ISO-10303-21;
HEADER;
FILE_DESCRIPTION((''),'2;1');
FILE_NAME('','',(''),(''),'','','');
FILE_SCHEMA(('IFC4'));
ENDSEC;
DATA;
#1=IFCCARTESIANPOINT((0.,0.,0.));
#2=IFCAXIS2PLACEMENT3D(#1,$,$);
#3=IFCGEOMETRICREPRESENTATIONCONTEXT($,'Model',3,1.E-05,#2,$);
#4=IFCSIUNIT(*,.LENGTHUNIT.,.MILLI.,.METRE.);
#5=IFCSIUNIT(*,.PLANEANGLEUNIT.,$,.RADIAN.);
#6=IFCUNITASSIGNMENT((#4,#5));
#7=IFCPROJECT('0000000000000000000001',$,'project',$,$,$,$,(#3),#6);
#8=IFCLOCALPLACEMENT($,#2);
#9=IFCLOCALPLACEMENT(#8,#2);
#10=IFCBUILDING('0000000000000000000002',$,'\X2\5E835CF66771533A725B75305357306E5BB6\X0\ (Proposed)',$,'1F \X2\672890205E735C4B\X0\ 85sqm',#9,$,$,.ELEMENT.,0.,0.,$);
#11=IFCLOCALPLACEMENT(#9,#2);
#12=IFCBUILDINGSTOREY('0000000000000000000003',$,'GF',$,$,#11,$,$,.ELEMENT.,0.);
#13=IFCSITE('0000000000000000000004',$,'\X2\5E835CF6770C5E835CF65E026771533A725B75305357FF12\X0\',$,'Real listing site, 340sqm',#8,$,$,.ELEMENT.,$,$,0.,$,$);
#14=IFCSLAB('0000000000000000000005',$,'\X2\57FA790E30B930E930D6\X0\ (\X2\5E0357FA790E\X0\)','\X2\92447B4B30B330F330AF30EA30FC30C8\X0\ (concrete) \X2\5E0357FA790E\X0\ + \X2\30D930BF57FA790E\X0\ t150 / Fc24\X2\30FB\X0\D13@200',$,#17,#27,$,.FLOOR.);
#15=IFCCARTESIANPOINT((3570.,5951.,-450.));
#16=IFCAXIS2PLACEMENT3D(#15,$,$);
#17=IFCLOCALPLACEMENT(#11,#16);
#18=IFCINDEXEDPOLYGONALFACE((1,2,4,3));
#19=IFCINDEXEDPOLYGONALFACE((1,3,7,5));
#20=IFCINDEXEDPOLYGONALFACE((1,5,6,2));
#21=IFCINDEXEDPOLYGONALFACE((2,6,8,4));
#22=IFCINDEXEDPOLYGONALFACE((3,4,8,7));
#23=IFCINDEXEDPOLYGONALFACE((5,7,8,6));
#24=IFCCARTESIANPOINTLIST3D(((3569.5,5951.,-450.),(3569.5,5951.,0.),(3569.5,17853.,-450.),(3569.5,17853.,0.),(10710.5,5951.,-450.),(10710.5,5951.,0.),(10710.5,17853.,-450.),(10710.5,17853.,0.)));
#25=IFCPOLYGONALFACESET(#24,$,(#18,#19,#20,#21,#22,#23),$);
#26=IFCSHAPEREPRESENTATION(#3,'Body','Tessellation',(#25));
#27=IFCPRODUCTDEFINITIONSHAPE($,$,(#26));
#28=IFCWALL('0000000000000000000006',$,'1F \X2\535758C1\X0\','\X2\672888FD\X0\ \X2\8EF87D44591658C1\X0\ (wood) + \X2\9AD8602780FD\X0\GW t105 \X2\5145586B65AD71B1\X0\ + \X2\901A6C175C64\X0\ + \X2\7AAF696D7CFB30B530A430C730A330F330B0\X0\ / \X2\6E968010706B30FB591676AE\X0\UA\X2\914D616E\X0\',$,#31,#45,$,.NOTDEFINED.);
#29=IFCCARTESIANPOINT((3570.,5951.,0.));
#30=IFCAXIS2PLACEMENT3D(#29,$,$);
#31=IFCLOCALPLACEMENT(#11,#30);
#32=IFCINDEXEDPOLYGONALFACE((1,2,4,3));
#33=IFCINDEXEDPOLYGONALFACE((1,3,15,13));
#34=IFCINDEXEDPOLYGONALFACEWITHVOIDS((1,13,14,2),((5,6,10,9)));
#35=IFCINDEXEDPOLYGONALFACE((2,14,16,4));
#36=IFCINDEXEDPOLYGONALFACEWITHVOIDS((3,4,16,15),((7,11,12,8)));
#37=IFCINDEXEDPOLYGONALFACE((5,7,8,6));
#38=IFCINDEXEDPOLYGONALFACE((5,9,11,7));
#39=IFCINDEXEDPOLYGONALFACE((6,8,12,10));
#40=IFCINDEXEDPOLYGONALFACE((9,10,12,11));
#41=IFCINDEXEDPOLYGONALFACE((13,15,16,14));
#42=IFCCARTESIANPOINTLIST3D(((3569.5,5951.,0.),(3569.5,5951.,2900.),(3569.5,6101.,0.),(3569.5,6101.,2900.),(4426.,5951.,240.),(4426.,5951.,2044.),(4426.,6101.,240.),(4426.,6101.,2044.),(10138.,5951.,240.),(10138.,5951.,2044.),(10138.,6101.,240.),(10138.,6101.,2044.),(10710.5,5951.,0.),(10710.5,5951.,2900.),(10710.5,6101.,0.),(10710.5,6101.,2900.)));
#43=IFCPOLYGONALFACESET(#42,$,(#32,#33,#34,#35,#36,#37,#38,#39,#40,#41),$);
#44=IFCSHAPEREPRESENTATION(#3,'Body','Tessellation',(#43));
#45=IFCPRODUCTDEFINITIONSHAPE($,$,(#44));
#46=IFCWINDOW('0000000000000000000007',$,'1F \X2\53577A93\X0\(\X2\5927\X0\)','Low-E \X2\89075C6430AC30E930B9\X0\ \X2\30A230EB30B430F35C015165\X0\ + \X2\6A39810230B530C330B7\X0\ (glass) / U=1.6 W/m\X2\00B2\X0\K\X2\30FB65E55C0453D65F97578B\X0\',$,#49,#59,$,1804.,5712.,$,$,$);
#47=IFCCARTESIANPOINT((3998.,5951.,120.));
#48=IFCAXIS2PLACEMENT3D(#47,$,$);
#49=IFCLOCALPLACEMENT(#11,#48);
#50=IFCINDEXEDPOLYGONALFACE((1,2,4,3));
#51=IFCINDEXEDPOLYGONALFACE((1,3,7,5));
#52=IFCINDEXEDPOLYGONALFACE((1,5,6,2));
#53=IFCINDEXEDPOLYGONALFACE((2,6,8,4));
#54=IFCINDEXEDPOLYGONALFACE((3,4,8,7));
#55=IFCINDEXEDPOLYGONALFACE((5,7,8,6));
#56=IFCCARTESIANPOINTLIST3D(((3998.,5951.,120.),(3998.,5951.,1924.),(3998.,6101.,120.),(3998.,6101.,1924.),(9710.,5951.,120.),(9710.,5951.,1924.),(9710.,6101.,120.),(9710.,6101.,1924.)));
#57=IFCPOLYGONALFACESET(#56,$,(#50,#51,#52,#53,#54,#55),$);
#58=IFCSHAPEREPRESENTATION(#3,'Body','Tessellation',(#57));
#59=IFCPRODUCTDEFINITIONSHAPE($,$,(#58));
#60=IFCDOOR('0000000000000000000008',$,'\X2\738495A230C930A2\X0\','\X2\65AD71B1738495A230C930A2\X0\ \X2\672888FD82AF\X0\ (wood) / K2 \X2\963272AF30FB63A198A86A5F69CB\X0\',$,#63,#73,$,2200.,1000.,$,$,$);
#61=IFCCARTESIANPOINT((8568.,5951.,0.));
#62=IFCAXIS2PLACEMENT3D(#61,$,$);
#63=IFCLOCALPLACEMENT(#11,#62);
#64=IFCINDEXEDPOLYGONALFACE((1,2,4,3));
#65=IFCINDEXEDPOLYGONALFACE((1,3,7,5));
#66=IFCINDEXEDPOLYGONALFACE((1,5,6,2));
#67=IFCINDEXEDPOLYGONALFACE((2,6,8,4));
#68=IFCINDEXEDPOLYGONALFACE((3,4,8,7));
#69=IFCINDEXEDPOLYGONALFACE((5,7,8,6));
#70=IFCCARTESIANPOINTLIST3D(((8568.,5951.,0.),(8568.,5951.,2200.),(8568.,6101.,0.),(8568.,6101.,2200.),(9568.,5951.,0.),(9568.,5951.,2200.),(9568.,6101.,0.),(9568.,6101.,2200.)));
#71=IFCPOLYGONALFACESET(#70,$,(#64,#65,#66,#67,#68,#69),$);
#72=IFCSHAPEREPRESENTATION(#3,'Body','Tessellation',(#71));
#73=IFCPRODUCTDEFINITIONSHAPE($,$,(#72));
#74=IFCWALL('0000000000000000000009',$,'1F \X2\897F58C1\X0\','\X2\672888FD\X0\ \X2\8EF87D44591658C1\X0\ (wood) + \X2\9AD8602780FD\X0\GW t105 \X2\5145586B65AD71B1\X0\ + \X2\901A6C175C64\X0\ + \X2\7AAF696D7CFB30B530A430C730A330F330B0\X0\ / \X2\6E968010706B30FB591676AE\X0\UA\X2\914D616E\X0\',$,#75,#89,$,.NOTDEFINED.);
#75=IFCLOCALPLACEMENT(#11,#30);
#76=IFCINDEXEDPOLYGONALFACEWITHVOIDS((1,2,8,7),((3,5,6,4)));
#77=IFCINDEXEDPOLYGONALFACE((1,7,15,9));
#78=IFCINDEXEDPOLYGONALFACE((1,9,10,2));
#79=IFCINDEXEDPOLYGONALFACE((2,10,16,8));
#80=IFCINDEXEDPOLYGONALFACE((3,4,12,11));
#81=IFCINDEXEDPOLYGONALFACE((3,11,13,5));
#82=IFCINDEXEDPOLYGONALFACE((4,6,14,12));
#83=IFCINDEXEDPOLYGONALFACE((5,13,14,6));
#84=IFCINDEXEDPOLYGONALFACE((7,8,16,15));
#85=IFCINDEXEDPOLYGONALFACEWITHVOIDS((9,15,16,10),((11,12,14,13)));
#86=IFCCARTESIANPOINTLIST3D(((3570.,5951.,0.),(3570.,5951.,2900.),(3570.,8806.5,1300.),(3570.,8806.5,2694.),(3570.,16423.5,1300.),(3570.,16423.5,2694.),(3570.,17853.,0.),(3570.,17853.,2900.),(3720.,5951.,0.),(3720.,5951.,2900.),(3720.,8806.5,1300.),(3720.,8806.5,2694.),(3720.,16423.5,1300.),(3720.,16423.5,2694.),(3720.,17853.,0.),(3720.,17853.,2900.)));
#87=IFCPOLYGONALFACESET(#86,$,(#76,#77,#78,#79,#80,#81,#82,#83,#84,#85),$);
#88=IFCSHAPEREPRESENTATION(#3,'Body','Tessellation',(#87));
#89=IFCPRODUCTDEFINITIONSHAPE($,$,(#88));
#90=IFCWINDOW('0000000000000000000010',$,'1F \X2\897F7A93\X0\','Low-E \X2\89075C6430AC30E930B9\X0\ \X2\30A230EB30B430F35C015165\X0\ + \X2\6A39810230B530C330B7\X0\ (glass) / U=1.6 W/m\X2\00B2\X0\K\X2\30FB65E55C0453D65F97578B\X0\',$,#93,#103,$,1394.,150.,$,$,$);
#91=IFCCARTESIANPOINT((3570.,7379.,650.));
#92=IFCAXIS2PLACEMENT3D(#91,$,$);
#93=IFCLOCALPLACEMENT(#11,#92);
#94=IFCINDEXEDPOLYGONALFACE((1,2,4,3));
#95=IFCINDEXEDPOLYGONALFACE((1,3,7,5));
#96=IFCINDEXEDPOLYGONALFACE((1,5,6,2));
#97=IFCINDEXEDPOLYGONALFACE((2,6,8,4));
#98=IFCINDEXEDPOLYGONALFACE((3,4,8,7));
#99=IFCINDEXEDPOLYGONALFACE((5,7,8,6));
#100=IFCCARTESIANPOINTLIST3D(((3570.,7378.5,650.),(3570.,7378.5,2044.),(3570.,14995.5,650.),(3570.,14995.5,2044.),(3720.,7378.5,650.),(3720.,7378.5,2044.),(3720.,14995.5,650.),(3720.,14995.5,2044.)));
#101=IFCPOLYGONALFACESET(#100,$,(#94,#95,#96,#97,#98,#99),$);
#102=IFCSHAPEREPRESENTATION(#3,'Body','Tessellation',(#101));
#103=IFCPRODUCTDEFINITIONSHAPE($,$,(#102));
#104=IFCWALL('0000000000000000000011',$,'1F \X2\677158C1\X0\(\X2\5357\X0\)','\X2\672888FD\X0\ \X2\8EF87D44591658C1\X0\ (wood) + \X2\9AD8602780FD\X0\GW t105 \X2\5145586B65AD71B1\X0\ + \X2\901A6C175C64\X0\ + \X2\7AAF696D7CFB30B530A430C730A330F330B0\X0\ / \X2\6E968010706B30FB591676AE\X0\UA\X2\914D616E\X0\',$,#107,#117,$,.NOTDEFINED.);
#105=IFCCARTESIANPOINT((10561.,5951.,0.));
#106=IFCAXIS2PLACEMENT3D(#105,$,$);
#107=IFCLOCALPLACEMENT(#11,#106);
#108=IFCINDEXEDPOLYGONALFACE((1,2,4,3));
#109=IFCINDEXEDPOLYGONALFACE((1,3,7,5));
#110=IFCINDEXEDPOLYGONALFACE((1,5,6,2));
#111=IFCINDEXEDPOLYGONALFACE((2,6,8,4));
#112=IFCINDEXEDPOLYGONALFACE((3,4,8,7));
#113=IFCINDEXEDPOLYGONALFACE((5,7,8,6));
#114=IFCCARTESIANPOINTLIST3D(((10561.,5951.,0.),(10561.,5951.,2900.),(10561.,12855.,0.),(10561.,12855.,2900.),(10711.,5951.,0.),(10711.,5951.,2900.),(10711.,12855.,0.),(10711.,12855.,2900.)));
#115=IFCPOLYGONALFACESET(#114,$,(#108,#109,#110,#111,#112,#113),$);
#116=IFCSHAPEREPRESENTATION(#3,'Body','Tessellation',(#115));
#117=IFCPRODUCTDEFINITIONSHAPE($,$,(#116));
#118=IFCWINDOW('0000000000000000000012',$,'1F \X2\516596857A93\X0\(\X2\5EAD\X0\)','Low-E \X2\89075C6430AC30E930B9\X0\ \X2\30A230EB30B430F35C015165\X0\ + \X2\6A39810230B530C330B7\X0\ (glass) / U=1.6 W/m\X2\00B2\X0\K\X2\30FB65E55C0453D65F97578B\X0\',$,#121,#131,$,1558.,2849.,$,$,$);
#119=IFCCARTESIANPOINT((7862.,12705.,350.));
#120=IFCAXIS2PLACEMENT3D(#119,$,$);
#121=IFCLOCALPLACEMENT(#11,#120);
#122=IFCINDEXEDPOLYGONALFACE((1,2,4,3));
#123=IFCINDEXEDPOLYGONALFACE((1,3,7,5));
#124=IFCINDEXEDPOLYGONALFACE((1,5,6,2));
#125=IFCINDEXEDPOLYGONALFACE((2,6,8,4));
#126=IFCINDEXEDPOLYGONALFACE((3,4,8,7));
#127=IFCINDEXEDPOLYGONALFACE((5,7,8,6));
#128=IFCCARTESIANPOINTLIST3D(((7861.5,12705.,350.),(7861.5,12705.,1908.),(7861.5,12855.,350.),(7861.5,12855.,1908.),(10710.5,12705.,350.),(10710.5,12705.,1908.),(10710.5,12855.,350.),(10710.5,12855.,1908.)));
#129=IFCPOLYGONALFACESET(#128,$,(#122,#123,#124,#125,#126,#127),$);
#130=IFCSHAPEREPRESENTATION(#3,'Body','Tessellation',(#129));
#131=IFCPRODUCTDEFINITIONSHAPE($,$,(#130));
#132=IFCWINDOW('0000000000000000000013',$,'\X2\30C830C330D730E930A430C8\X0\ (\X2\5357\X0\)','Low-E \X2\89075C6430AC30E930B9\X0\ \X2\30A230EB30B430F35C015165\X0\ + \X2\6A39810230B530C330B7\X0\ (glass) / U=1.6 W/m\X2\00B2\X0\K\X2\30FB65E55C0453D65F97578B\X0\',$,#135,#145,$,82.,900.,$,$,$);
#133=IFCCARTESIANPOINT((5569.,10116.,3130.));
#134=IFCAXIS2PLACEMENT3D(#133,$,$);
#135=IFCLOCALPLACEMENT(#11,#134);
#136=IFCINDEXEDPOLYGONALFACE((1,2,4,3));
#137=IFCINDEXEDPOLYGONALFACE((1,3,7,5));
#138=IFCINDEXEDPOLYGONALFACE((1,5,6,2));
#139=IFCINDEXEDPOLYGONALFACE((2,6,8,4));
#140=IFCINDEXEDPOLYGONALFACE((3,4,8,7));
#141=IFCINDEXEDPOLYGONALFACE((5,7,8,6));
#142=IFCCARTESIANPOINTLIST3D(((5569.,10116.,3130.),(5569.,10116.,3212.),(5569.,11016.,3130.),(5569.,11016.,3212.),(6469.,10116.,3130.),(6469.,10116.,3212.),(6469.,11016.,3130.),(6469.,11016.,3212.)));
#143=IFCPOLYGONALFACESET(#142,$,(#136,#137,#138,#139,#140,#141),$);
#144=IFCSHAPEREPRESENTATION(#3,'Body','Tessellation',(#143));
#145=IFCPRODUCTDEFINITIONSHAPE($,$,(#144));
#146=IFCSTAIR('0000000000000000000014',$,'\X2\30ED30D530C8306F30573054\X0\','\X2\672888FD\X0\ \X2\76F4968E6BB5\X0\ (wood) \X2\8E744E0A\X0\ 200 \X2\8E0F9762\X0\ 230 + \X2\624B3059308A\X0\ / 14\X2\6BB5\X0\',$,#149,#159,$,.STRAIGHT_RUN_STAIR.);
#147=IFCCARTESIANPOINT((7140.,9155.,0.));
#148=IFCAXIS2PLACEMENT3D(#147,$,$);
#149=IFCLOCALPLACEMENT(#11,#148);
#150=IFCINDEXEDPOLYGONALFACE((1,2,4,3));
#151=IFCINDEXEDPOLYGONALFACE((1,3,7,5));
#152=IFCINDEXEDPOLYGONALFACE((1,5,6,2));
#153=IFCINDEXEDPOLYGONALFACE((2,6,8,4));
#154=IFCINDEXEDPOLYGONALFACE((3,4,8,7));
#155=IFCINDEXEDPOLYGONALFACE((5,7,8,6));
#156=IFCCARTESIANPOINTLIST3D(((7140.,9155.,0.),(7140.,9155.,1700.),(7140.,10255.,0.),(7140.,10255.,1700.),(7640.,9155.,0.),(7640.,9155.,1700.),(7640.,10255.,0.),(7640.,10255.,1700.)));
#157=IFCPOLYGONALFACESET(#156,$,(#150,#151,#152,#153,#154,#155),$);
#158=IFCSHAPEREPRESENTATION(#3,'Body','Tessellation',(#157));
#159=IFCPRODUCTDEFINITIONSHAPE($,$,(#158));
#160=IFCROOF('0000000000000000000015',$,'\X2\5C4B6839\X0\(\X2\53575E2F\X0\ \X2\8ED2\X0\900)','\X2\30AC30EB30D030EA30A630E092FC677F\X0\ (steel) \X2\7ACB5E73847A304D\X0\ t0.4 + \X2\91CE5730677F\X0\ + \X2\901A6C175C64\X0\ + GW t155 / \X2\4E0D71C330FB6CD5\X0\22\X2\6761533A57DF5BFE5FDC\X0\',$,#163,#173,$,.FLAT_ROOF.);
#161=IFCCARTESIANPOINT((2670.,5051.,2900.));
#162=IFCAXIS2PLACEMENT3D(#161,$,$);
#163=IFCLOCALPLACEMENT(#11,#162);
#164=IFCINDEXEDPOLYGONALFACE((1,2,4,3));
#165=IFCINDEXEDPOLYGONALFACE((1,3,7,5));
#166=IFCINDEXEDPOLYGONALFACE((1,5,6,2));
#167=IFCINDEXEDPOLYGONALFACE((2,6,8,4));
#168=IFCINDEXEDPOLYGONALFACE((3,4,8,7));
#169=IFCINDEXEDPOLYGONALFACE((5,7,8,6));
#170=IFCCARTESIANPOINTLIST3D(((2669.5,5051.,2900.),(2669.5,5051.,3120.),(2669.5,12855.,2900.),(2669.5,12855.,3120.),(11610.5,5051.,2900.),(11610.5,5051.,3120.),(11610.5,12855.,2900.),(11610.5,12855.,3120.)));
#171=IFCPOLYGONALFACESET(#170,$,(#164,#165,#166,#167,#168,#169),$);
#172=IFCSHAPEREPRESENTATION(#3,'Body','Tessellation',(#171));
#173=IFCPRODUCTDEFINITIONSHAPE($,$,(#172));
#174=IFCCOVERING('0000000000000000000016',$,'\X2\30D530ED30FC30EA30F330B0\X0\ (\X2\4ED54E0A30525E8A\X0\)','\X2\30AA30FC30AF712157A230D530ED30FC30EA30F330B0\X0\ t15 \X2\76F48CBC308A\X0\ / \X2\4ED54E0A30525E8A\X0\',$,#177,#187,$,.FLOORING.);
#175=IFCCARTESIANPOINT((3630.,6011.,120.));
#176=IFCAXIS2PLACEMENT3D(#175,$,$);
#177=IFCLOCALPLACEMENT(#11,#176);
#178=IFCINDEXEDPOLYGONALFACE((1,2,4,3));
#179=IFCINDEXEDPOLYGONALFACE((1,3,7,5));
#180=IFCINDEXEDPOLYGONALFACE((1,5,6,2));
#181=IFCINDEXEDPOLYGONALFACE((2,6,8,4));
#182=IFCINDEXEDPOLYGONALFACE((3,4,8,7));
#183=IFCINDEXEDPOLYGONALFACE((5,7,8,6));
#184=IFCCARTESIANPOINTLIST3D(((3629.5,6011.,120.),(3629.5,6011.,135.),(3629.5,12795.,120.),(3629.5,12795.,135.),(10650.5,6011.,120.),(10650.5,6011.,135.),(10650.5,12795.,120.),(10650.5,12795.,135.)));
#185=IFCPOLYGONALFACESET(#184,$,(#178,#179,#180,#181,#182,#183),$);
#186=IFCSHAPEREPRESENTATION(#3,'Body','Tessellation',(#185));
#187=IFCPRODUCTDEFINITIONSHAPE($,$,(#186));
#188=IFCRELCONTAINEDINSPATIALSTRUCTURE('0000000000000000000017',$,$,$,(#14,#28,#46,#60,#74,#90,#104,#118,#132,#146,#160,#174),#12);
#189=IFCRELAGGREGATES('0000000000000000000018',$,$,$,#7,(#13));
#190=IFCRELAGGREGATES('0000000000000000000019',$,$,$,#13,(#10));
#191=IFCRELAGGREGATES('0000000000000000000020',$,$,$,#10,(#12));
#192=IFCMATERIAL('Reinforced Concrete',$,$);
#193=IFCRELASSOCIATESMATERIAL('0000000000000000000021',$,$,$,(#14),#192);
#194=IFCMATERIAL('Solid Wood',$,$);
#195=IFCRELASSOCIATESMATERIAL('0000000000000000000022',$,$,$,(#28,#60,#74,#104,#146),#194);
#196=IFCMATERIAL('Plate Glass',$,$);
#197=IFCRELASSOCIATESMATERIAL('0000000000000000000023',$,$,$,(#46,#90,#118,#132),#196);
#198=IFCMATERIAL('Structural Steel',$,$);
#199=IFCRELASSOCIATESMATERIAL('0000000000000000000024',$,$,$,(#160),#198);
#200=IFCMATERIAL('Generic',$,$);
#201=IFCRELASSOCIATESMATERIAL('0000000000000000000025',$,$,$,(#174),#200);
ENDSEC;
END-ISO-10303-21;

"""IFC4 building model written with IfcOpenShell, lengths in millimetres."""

from ifc_helpers import new_model, si_unit, frame, frame_2d, origin, place, context, project, spatial, rectangle, extrude, material, element, fill, save


model = new_model("IFC4")

# Units and contexts
model_context = context("Model", 3, precision=1e-05, world=origin())
ifc_project = project(units=[si_unit("LENGTHUNIT", "METRE", prefix="MILLI"), si_unit("PLANEANGLEUNIT", "RADIAN")], contexts=[model_context])

# Site, building, storey
site_placement = place(None, origin())
site = spatial("IfcSite", under=ifc_project, at=site_placement, Name="広島県広島市東区牛田南２", ObjectType="Real listing site, 340sqm", CompositionType="ELEMENT", RefElevation=0.0)
building_placement = place(site_placement, origin())
building = spatial("IfcBuilding", under=site, at=building_placement, Name="広島東区牛田南の家 (Proposed)", ObjectType="1F 木造平屋 85sqm", CompositionType="ELEMENT", ElevationOfRefHeight=0.0, ElevationOfTerrain=0.0)
storey_placement = place(building_placement, origin())
storey = spatial("IfcBuildingStorey", under=building, at=storey_placement, Name="GF", CompositionType="ELEMENT", Elevation=0.0)

# Slab
ifc_material_1 = material(Name="Reinforced Concrete")
slab_1_placement = place(storey_placement, frame((3570.0, 5951.0, -450.0)))
element("IfcSlab", 1, at=slab_1_placement, inside=storey, material=ifc_material_1, Name="基礎スラブ (布基礎)", Description="鉄筋コンクリート (concrete) 布基礎 + ベタ基礎 t150 / Fc24・D13@200", PredefinedType="FLOOR", context=model_context, shape_type="SweptSolid", body=[
    extrude(rectangle(XDim=7141.0, YDim=11902.0, at=frame_2d((3570.0, 5951.0))), frame((3570.0, 5951.0, -450.0)), (0.0, 0.0, 1.0), 450.0),
])
ifc_material_2 = material(Name="Solid Wood")

# Wall, openings, window, door
wall_1_placement = place(storey_placement, frame((3570.0, 5951.0, 0.0)))
wall_1 = element("IfcWall", 2, at=wall_1_placement, inside=storey, material=ifc_material_2, Name="1F 南壁", Description="木製 軸組外壁 (wood) + 高性能GW t105 充填断熱 + 通気層 + 窯業系サイディング / 準耐火・外皮UA配慮", PredefinedType="NOTDEFINED", context=model_context, shape_type="SweptSolid", body=[
    extrude(rectangle(XDim=7141.0, YDim=150.0, at=frame_2d((3570.0, 75.0))), frame((3570.0, 5951.0, 0.0)), (0.0, 0.0, 1.0), 2900.0),
])
opening_1_placement = place(storey_placement, frame((3998.0, 5951.0, 120.0)))
opening_1 = element("IfcOpeningElement", 3, at=opening_1_placement, cuts=wall_1, PredefinedType="NOTDEFINED", context=model_context, shape_type="SweptSolid", body=[
    extrude(rectangle(XDim=5712.0, YDim=150.0, at=frame_2d((2856.0, 75.0))), frame((3998.0, 5951.0, 120.0)), (0.0, 0.0, 1.0), 1804.0),
])
opening_2_placement = place(storey_placement, frame((8568.0, 5951.0, 0.0)))
opening_2 = element("IfcOpeningElement", 4, at=opening_2_placement, cuts=wall_1, PredefinedType="NOTDEFINED", context=model_context, shape_type="SweptSolid", body=[
    extrude(rectangle(XDim=1000.0, YDim=150.0, at=frame_2d((500.0, 75.0))), frame((8568.0, 5951.0, 0.0)), (0.0, 0.0, 1.0), 2200.0),
])
ifc_material_3 = material(Name="Plate Glass")
window_1_placement = place(storey_placement, frame((3998.0, 5951.0, 120.0)))
window_1 = element("IfcWindow", 5, at=window_1_placement, inside=storey, material=ifc_material_3, Name="1F 南窓(大)", Description="Low-E 複層ガラス アルゴン封入 + 樹脂サッシ (glass) / U=1.6 W/m²K・日射取得型", OverallHeight=1804.0, OverallWidth=5712.0, context=model_context, shape_type="SweptSolid", body=[
    extrude(rectangle(XDim=5712.0, YDim=150.0, at=frame_2d((2856.0, 75.0))), frame((3998.0, 5951.0, 120.0)), (0.0, 0.0, 1.0), 1804.0),
])
fill(opening_1, window_1)
door_1_placement = place(storey_placement, frame((8568.0, 5951.0, 0.0)))
door_1 = element("IfcDoor", 6, at=door_1_placement, inside=storey, material=ifc_material_2, Name="玄関ドア", Description="断熱玄関ドア 木製芯 (wood) / K2 防犯・採風機構", OverallHeight=2200.0, OverallWidth=1000.0, context=model_context, shape_type="SweptSolid", body=[
    extrude(rectangle(XDim=1000.0, YDim=150.0, at=frame_2d((500.0, 75.0))), frame((8568.0, 5951.0, 0.0)), (0.0, 0.0, 1.0), 2200.0),
])
fill(opening_2, door_1)

# Walls, openings, windows
wall_2_placement = place(storey_placement, frame((3570.0, 5951.0, 0.0)))
wall_2 = element("IfcWall", 7, at=wall_2_placement, inside=storey, material=ifc_material_2, Name="1F 西壁", Description="木製 軸組外壁 (wood) + 高性能GW t105 充填断熱 + 通気層 + 窯業系サイディング / 準耐火・外皮UA配慮", PredefinedType="NOTDEFINED", context=model_context, shape_type="SweptSolid", body=[
    extrude(rectangle(XDim=150.0, YDim=11902.0, at=frame_2d((75.0, 5951.0))), frame((3570.0, 5951.0, 0.0)), (0.0, 0.0, 1.0), 2900.0),
])
opening_3_placement = place(storey_placement, frame((3570.0, 7379.0, 650.0)))
opening_3 = element("IfcOpeningElement", 8, at=opening_3_placement, cuts=wall_2, PredefinedType="NOTDEFINED", context=model_context, shape_type="SweptSolid", body=[
    extrude(rectangle(XDim=150.0, YDim=7617.0, at=frame_2d((75.0, 3808.0))), frame((3570.0, 7379.0, 650.0)), (0.0, 0.0, 1.0), 1394.0),
])
window_2_placement = place(storey_placement, frame((3570.0, 7379.0, 650.0)))
window_2 = element("IfcWindow", 9, at=window_2_placement, inside=storey, material=ifc_material_3, Name="1F 西窓", Description="Low-E 複層ガラス アルゴン封入 + 樹脂サッシ (glass) / U=1.6 W/m²K・日射取得型", OverallHeight=1394.0, OverallWidth=150.0, context=model_context, shape_type="SweptSolid", body=[
    extrude(rectangle(XDim=150.0, YDim=7617.0, at=frame_2d((75.0, 3808.0))), frame((3570.0, 7379.0, 650.0)), (0.0, 0.0, 1.0), 1394.0),
])
fill(opening_3, window_2)
wall_3_placement = place(storey_placement, frame((10561.0, 5951.0, 0.0)))
wall_3 = element("IfcWall", 10, at=wall_3_placement, inside=storey, material=ifc_material_2, Name="1F 東壁(南)", Description="木製 軸組外壁 (wood) + 高性能GW t105 充填断熱 + 通気層 + 窯業系サイディング / 準耐火・外皮UA配慮", PredefinedType="NOTDEFINED", context=model_context, shape_type="SweptSolid", body=[
    extrude(rectangle(XDim=150.0, YDim=6904.0, at=frame_2d((75.0, 3452.0))), frame((10561.0, 5951.0, 0.0)), (0.0, 0.0, 1.0), 2900.0),
])
opening_4_placement = place(storey_placement, frame((7862.0, 12705.0, 350.0)))
opening_4 = element("IfcOpeningElement", 11, at=opening_4_placement, cuts=wall_3, PredefinedType="NOTDEFINED", context=model_context, shape_type="SweptSolid", body=[
    extrude(rectangle(XDim=2849.0, YDim=150.0, at=frame_2d((1424.0, 75.0))), frame((7862.0, 12705.0, 350.0)), (0.0, 0.0, 1.0), 1558.0),
])
window_3_placement = place(storey_placement, frame((7862.0, 12705.0, 350.0)))
window_3 = element("IfcWindow", 12, at=window_3_placement, inside=storey, material=ifc_material_3, Name="1F 入隅窓(庭)", Description="Low-E 複層ガラス アルゴン封入 + 樹脂サッシ (glass) / U=1.6 W/m²K・日射取得型", OverallHeight=1558.0, OverallWidth=2849.0, context=model_context, shape_type="SweptSolid", body=[
    extrude(rectangle(XDim=2849.0, YDim=150.0, at=frame_2d((1424.0, 75.0))), frame((7862.0, 12705.0, 350.0)), (0.0, 0.0, 1.0), 1558.0),
])
fill(opening_4, window_3)

# Window
window_4_placement = place(storey_placement, frame((5569.0, 10116.0, 3130.0)))
element("IfcWindow", 13, at=window_4_placement, inside=storey, material=ifc_material_3, Name="トップライト (南)", Description="Low-E 複層ガラス アルゴン封入 + 樹脂サッシ (glass) / U=1.6 W/m²K・日射取得型", OverallHeight=82.0, OverallWidth=900.0, context=model_context, shape_type="SweptSolid", body=[
    extrude(rectangle(XDim=900.0, YDim=900.0, at=frame_2d((450.0, 450.0))), frame((5569.0, 10116.0, 3130.0)), (0.0, 0.0, 1.0), 82.0),
])

# Stair
stair_placement = place(storey_placement, frame((7140.0, 9155.0, 0.0)))
element("IfcStair", 14, at=stair_placement, inside=storey, material=ifc_material_2, Name="ロフトはしご", Description="木製 直階段 (wood) 蹴上 200 踏面 230 + 手すり / 14段", PredefinedType="STRAIGHT_RUN_STAIR", context=model_context, shape_type="SweptSolid", body=[
    extrude(rectangle(XDim=500.0, YDim=1100.0, at=frame_2d((250.0, 550.0))), frame((7140.0, 9155.0, 0.0)), (0.0, 0.0, 1.0), 1700.0),
])

# Roof
ifc_material_4 = material(Name="Structural Steel")
roof_placement = place(storey_placement, frame((2670.0, 5051.0, 2900.0)))
element("IfcRoof", 15, at=roof_placement, inside=storey, material=ifc_material_4, Name="屋根(南帯 軒900)", Description="ガルバリウム鋼板 (steel) 立平葺き t0.4 + 野地板 + 通気層 + GW t155 / 不燃・法22条区域対応", PredefinedType="FLAT_ROOF", context=model_context, shape_type="SweptSolid", body=[
    extrude(rectangle(XDim=8941.0, YDim=7804.0, at=frame_2d((4470.0, 3902.0))), frame((2670.0, 5051.0, 2900.0)), (0.0, 0.0, 1.0), 220.0),
])

# Covering
ifc_material_5 = material(Name="Generic")
covering_placement = place(storey_placement, frame((3630.0, 6011.0, 120.0)))
element("IfcCovering", 16, at=covering_placement, inside=storey, material=ifc_material_5, Name="フローリング (仕上げ床)", Description="オーク無垢フローリング t15 直貼り / 仕上げ床", PredefinedType="FLOORING", context=model_context, shape_type="SweptSolid", body=[
    extrude(rectangle(XDim=7021.0, YDim=6784.0, at=frame_2d((3510.0, 3392.0))), frame((3630.0, 6011.0, 120.0)), (0.0, 0.0, 1.0), 15.0),
])

save(model, "model.ifc")
